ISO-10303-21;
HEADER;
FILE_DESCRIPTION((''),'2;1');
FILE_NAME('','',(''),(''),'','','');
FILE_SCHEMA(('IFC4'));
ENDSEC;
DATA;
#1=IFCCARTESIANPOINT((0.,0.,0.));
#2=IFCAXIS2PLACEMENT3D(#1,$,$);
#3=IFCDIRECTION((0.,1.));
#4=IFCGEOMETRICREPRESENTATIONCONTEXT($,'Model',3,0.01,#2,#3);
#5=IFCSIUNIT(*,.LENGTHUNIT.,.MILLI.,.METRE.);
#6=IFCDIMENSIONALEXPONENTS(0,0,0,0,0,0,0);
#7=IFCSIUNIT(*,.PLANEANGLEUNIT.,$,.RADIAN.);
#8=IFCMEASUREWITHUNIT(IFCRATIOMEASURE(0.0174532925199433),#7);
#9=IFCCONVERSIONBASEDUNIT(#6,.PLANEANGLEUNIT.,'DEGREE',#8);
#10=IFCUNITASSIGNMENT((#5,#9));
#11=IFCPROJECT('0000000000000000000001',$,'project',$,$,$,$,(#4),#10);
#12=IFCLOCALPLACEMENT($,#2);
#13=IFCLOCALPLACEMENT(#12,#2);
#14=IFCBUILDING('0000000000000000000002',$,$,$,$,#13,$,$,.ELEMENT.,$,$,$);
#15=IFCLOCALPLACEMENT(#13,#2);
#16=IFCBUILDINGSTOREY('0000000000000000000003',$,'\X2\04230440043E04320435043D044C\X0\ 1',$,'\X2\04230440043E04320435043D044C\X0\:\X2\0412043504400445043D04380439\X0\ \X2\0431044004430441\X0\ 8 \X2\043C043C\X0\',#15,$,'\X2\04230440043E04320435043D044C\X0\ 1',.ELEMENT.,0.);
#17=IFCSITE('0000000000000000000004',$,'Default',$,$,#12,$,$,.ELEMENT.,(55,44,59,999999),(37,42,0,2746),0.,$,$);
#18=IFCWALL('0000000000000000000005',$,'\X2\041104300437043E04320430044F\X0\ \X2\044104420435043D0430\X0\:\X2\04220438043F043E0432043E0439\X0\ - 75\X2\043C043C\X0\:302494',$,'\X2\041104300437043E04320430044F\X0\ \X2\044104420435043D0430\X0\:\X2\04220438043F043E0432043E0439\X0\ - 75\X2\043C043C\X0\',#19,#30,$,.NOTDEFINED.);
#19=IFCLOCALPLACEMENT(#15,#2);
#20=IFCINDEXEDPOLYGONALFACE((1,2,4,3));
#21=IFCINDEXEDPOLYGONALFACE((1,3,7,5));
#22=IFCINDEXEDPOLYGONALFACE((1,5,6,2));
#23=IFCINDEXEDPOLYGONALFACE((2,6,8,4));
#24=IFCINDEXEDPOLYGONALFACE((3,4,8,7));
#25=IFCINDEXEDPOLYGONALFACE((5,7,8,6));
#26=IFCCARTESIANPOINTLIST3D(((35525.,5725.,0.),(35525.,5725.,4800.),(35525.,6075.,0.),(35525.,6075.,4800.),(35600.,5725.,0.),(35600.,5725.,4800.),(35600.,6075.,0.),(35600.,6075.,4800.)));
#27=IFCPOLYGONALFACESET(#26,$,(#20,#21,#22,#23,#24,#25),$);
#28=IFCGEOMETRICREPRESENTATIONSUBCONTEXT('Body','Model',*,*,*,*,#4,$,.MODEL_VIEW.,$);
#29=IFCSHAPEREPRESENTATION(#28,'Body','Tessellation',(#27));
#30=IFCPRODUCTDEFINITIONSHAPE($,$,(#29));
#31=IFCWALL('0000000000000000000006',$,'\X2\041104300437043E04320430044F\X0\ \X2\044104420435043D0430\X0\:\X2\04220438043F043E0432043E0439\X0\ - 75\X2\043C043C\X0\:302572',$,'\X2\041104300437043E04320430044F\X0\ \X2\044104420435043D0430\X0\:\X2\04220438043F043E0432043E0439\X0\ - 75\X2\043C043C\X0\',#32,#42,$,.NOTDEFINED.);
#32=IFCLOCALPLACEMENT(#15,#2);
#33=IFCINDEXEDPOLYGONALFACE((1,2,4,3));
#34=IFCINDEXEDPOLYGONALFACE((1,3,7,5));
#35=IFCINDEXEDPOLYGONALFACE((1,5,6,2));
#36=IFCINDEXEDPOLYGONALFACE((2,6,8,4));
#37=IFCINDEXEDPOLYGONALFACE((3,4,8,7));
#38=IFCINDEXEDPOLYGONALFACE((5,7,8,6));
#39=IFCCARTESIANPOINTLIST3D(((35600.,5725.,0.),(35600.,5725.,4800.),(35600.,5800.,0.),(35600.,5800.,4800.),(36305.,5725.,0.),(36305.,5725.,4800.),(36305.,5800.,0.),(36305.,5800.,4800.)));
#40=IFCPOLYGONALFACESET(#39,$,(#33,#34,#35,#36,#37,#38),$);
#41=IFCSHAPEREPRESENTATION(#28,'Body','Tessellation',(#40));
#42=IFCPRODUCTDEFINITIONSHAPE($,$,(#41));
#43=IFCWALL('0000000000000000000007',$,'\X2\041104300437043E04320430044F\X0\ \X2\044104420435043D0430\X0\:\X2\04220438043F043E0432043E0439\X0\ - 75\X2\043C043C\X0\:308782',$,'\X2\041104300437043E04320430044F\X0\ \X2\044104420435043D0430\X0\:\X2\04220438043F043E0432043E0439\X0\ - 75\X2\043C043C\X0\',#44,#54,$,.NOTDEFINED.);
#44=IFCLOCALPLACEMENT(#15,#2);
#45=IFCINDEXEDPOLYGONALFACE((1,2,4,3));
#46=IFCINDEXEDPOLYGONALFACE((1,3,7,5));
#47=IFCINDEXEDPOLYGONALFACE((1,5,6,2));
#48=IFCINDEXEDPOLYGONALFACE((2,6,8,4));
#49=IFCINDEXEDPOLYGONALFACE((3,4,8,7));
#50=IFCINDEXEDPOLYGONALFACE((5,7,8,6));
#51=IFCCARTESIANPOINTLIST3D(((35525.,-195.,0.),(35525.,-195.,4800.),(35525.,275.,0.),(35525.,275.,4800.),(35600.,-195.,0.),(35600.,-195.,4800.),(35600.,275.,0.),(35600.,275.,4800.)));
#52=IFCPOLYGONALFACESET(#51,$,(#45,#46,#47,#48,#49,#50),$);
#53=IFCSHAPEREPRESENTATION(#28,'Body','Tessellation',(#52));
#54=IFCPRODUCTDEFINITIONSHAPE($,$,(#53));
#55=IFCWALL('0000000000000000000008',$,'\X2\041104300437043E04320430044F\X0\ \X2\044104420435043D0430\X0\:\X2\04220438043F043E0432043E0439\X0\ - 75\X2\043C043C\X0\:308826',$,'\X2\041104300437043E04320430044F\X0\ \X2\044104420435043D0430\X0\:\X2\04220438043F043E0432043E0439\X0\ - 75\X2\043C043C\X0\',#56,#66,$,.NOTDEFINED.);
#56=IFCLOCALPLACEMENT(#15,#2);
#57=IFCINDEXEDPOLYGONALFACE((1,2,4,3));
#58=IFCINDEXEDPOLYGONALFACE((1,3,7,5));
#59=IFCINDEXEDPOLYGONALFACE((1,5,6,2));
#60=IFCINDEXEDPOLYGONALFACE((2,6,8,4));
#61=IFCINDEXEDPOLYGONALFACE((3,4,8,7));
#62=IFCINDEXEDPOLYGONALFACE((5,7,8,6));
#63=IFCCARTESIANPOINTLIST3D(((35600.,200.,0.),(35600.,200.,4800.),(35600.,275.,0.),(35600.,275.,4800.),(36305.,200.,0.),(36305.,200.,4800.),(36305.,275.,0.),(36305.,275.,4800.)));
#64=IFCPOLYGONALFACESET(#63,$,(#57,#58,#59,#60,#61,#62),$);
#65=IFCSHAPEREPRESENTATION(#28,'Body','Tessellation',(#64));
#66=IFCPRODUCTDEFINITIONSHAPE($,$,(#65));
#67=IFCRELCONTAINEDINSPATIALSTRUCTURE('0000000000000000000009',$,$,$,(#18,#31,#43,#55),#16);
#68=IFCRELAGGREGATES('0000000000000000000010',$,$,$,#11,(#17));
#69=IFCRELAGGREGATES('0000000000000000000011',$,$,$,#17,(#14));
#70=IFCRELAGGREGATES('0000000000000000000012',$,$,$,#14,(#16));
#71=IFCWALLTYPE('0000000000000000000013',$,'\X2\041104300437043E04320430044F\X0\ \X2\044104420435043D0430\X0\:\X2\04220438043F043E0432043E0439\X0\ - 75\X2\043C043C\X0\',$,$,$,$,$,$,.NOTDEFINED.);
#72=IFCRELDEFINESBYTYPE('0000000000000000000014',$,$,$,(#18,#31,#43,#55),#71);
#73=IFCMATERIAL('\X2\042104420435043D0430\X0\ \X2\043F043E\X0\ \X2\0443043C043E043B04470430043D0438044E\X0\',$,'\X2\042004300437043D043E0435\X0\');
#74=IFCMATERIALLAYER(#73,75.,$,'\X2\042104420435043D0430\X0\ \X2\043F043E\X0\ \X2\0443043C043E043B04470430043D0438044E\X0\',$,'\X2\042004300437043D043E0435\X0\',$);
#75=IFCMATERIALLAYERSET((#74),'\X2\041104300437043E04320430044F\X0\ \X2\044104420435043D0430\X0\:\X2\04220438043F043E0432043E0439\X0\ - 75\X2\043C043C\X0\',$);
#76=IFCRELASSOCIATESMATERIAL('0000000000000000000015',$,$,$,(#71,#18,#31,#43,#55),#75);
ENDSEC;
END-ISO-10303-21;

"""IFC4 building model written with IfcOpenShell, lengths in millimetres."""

from ifc_helpers import new_model, entity, si_unit, converted_unit, direction, frame, frame_2d, origin, place, context, subcontext, project, spatial, rectangle, extrude, material, layer, layer_set, layer_usage, type_object, element, save


model = new_model("IFC4")

# Units and contexts
model_context = context("Model", 3, precision=0.01, world=origin(), true_north=direction((0.0, 1.0)))
body_context = subcontext(model_context, "Body", "Model", "MODEL_VIEW")
ifc_project = project(units=[si_unit("LENGTHUNIT", "METRE", prefix="MILLI"), converted_unit("PLANEANGLEUNIT", "DEGREE", entity("IfcRatioMeasure", 0.0174532925199433), si_unit("PLANEANGLEUNIT", "RADIAN"), dimensions=[0, 0, 0, 0, 0, 0, 0])], contexts=[model_context])

# Site, building, storey
site_placement = place(None, origin())
site = spatial("IfcSite", under=ifc_project, at=site_placement, Name="Default", CompositionType="ELEMENT", RefLatitude=(55, 44, 59, 999999), RefLongitude=(37, 42, 0, 2746), RefElevation=0.0)
building_placement = place(site_placement, origin())
building = spatial("IfcBuilding", under=site, at=building_placement, CompositionType="ELEMENT")
storey_placement = place(building_placement, origin())
storey = spatial("IfcBuildingStorey", under=building, at=storey_placement, Name="Уровень 1", ObjectType="Уровень:Верхний брус 8 мм", LongName="Уровень 1", CompositionType="ELEMENT", Elevation=0.0)

# Shared definitions
ifc_material_1 = material(Name="Стена по умолчанию", Category="Разное")

# Walls
ifc_layer_1 = layer(ifc_material_1, 75.0, Name="Стена по умолчанию", Category="Разное")
ifc_layer_set_1 = layer_set([ifc_layer_1], Name="Базовая стена:Типовой - 75мм")
ifc_layer_usage_1 = layer_usage(ifc_layer_set_1, "AXIS2", "NEGATIVE", 37.5)
wall_type_1 = type_object("IfcWallType", Name="Базовая стена:Типовой - 75мм", PredefinedType="NOTDEFINED", material=ifc_layer_set_1)
wall_1_placement = place(storey_placement, frame((35562.5, 6075.0, 0.0), z_axis=(0.0, 0.0, 1.0), x_axis=(0.0, -1.0, 0.0)))
element("IfcWall", 1, at=wall_1_placement, inside=storey, type_object=wall_type_1, material=ifc_layer_usage_1, Name="Базовая стена:Типовой - 75мм:302494", ObjectType="Базовая стена:Типовой - 75мм", PredefinedType="NOTDEFINED", context=body_context, shape_type="SweptSolid", body=[
    extrude(rectangle(XDim=350.0, YDim=75.0, at=frame_2d((175.0, 0.0), x_axis=(-1.0, 0.0))), origin(), (0.0, 0.0, 1.0), 4800.0),
])
ifc_layer_usage_2 = layer_usage(ifc_layer_set_1, "AXIS2", "NEGATIVE", 37.5)
wall_2_placement = place(storey_placement, frame((35600.0, 5762.5, 0.0)))
element("IfcWall", 2, at=wall_2_placement, inside=storey, type_object=wall_type_1, material=ifc_layer_usage_2, Name="Базовая стена:Типовой - 75мм:302572", ObjectType="Базовая стена:Типовой - 75мм", PredefinedType="NOTDEFINED", context=body_context, shape_type="SweptSolid", body=[
    extrude(rectangle(XDim=705.0, YDim=75.0, at=frame_2d((352.5, 0.0), x_axis=(-1.0, 0.0))), origin(), (0.0, 0.0, 1.0), 4800.0),
])
ifc_layer_usage_3 = layer_usage(ifc_layer_set_1, "AXIS2", "NEGATIVE", 37.5)
wall_3_placement = place(storey_placement, frame((35562.5, -195.0, 0.0), z_axis=(0.0, 0.0, 1.0), x_axis=(0.0, 1.0, 0.0)))
element("IfcWall", 3, at=wall_3_placement, inside=storey, type_object=wall_type_1, material=ifc_layer_usage_3, Name="Базовая стена:Типовой - 75мм:308782", ObjectType="Базовая стена:Типовой - 75мм", PredefinedType="NOTDEFINED", context=body_context, shape_type="SweptSolid", body=[
    extrude(rectangle(XDim=470.0, YDim=75.0, at=frame_2d((235.0, 0.0), x_axis=(-1.0, 0.0))), origin(), (0.0, 0.0, 1.0), 4800.0),
])
ifc_layer_usage_4 = layer_usage(ifc_layer_set_1, "AXIS2", "NEGATIVE", 37.5)
wall_4_placement = place(storey_placement, frame((35600.0, 237.5, 0.0)))
element("IfcWall", 4, at=wall_4_placement, inside=storey, type_object=wall_type_1, material=ifc_layer_usage_4, Name="Базовая стена:Типовой - 75мм:308826", ObjectType="Базовая стена:Типовой - 75мм", PredefinedType="NOTDEFINED", context=body_context, shape_type="SweptSolid", body=[
    extrude(rectangle(XDim=705.0, YDim=75.0, at=frame_2d((352.5, 0.0), x_axis=(-1.0, 0.0))), origin(), (0.0, 0.0, 1.0), 4800.0),
])

save(model, "model.ifc")
